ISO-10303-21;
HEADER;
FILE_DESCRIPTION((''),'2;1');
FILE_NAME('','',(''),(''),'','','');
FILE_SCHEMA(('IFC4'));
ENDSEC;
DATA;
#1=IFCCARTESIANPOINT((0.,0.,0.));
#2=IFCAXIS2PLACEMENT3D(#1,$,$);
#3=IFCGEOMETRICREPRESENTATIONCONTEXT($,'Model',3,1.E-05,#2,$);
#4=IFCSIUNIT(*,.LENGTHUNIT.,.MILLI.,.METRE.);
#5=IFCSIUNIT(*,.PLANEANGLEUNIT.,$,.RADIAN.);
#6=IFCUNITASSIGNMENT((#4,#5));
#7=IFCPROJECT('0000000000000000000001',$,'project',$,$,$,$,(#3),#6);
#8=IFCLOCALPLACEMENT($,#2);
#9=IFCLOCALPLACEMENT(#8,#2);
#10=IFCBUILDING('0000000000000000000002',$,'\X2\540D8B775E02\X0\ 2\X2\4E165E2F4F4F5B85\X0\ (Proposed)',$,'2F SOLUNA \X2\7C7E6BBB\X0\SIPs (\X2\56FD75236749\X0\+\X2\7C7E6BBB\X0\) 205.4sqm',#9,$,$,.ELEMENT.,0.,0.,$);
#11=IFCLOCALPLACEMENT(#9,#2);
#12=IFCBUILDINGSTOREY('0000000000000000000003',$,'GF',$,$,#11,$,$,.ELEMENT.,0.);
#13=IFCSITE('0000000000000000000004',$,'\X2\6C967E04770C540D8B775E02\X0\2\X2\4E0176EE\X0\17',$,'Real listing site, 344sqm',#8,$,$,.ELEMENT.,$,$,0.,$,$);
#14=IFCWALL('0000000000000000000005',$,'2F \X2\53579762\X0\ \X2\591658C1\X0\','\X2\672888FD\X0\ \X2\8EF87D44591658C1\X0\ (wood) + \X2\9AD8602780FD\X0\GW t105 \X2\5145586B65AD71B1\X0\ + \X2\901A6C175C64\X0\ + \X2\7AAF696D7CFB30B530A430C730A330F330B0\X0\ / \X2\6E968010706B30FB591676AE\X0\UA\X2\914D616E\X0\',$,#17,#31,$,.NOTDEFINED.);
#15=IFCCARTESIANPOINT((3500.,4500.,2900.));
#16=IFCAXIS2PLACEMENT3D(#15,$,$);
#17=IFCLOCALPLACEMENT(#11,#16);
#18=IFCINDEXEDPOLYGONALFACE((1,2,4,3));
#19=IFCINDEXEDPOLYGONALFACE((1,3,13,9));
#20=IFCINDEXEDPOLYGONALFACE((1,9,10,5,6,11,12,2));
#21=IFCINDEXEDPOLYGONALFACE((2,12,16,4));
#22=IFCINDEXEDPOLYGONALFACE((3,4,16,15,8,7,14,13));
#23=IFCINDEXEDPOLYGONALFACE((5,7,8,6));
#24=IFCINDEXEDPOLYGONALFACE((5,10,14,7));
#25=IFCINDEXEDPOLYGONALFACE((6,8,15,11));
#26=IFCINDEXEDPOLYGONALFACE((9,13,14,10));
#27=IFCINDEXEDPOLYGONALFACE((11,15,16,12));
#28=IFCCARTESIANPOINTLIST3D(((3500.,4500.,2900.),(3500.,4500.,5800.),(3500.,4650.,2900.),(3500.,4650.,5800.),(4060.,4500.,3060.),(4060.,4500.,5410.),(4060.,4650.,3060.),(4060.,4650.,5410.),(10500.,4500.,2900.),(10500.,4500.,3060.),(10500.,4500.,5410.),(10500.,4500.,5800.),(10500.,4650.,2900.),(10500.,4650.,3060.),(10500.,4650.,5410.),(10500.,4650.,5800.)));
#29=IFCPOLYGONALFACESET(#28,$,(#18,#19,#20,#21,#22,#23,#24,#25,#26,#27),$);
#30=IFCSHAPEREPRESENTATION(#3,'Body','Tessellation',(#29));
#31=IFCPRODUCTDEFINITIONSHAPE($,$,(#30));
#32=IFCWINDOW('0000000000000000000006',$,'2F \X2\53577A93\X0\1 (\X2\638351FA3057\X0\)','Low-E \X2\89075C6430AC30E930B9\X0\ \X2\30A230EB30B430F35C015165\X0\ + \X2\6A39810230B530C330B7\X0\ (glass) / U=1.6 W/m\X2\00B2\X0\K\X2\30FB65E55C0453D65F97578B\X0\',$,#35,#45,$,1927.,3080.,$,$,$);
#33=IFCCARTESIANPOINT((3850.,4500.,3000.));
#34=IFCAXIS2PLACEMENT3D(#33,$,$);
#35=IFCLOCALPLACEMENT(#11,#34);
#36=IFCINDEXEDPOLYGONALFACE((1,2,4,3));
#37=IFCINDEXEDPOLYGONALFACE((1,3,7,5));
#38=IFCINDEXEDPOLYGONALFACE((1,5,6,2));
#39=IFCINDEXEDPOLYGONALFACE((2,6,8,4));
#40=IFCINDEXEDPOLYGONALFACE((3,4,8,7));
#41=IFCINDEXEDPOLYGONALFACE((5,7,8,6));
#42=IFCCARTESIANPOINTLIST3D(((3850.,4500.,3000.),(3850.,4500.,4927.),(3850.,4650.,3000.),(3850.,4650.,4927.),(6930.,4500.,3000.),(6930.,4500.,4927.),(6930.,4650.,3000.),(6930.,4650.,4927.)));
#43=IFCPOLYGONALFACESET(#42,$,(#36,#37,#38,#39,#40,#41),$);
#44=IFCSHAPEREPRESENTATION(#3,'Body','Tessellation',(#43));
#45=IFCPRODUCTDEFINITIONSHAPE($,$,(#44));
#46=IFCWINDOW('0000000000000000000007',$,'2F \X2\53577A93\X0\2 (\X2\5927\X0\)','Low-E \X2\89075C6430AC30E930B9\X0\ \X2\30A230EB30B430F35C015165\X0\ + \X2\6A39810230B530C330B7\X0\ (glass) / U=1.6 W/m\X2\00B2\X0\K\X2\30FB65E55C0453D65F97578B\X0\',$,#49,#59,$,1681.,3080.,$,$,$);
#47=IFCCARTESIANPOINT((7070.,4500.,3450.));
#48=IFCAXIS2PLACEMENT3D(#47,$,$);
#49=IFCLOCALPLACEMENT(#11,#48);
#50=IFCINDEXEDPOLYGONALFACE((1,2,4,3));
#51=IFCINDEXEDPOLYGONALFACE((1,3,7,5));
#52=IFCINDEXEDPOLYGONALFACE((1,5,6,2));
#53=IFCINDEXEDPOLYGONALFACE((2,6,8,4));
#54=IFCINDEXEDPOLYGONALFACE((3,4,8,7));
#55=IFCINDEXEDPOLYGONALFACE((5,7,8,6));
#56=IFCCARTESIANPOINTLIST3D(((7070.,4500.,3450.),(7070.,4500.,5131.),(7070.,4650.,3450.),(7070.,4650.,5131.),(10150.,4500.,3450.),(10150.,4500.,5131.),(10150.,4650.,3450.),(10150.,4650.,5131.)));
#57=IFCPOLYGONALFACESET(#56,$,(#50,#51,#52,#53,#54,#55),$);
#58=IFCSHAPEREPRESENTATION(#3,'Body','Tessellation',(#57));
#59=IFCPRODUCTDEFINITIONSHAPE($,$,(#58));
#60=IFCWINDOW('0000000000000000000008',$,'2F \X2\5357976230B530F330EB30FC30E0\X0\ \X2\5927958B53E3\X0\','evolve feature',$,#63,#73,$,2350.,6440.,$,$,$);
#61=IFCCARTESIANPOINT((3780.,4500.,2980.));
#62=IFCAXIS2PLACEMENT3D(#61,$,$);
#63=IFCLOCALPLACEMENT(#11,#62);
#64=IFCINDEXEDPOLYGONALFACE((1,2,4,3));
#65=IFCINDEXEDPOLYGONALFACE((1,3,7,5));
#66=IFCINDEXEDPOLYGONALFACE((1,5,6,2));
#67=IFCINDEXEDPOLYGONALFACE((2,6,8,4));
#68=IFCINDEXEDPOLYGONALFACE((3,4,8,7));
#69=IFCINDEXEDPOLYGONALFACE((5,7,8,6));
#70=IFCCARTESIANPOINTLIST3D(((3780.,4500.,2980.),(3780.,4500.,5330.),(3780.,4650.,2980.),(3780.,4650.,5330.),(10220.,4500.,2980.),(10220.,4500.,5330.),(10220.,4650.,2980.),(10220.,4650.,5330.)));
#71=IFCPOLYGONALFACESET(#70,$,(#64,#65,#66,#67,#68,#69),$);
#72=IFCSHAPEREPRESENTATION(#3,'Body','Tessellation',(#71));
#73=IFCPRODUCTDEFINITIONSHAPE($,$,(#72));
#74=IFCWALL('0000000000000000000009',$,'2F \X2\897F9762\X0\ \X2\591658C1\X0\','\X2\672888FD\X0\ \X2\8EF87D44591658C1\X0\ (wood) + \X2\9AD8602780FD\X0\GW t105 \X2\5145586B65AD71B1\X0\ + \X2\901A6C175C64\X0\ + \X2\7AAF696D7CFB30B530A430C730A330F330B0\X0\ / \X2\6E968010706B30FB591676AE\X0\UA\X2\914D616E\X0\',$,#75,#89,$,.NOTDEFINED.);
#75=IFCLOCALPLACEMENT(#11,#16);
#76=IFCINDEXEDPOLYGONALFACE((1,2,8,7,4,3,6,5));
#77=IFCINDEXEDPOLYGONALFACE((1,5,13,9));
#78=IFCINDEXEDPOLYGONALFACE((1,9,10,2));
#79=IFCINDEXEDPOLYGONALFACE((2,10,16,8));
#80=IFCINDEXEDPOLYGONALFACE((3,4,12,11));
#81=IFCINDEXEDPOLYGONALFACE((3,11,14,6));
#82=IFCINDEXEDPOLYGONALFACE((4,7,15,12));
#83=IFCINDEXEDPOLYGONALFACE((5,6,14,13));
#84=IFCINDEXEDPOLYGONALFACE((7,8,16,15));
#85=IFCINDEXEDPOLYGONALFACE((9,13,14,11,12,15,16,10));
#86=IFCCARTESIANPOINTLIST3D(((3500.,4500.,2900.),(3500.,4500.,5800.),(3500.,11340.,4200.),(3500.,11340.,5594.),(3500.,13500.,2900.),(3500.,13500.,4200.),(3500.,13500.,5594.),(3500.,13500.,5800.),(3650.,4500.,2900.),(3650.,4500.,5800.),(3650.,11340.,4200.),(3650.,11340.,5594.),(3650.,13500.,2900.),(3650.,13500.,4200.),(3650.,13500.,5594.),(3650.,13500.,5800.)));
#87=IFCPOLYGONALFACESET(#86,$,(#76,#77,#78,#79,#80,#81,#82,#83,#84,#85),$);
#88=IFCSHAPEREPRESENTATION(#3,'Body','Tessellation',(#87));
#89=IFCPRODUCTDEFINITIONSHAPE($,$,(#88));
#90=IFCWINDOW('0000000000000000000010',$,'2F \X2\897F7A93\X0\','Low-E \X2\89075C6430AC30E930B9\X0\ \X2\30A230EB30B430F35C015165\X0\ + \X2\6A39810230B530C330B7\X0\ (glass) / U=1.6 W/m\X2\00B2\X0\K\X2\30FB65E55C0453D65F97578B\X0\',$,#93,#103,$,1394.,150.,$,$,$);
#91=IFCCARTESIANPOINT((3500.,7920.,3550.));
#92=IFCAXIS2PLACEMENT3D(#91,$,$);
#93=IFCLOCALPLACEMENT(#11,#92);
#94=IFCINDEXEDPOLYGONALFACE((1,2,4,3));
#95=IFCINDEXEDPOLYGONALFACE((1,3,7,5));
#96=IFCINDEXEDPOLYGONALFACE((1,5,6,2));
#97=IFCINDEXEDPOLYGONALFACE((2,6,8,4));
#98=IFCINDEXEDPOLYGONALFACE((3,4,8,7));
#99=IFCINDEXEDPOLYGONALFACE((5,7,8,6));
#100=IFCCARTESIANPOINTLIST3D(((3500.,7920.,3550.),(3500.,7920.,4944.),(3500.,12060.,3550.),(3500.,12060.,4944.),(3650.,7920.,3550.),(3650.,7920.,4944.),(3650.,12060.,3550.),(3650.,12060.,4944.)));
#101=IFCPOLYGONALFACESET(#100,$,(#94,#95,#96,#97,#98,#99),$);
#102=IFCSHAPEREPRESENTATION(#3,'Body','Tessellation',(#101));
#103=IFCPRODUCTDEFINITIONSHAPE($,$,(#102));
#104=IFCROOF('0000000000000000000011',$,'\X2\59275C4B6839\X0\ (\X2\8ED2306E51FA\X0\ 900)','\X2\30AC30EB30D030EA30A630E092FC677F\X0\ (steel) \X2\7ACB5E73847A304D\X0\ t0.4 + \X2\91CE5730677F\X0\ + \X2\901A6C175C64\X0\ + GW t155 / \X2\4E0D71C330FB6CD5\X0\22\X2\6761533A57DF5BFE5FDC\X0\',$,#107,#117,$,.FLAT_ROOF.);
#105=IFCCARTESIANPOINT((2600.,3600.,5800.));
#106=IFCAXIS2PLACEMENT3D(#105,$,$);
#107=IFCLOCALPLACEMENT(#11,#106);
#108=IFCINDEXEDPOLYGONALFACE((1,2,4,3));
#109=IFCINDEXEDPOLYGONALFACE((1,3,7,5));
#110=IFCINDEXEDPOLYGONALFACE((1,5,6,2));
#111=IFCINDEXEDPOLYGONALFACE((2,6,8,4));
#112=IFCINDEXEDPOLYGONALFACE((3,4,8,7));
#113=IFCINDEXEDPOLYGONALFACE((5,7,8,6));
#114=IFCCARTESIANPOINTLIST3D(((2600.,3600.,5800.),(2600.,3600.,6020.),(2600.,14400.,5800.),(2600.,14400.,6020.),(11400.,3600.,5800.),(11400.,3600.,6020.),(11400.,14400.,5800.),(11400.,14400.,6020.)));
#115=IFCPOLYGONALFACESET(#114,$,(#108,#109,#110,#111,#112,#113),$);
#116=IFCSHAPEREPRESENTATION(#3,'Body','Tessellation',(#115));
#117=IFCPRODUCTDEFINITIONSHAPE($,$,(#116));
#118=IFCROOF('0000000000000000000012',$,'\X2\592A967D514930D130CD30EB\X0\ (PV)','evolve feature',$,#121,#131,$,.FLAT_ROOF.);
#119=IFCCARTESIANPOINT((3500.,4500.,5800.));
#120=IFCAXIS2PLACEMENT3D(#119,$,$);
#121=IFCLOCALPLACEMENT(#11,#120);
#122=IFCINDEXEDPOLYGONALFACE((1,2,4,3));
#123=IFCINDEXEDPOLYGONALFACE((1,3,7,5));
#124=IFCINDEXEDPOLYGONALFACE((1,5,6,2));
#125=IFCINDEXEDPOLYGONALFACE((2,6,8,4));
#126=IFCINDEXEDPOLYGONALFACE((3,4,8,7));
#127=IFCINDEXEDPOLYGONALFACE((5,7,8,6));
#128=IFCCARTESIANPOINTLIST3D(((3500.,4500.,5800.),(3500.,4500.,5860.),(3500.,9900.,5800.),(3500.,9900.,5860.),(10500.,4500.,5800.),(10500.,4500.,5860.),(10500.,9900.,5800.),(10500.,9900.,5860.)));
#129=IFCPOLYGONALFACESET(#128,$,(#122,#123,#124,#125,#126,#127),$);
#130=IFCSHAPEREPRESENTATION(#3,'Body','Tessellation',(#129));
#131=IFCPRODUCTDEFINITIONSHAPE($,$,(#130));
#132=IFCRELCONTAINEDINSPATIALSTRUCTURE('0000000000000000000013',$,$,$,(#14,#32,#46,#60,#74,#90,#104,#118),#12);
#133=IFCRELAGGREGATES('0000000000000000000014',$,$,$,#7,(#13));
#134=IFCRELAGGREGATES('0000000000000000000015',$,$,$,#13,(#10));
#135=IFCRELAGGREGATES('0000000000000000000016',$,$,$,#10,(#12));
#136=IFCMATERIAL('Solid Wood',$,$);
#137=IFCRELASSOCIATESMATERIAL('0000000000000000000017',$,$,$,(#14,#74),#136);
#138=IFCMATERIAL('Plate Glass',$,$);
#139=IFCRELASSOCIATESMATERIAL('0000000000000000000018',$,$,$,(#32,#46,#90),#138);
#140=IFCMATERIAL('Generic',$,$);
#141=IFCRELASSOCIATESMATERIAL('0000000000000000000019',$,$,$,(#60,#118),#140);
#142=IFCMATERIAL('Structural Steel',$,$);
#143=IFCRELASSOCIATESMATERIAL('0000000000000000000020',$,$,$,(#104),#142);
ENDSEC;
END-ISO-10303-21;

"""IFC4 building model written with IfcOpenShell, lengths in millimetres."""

from ifc_helpers import new_model, si_unit, frame, frame_2d, origin, place, context, project, spatial, rectangle, extrude, material, element, fill, save


model = new_model("IFC4")

# Units and contexts
model_context = context("Model", 3, precision=1e-05, world=origin())
ifc_project = project(units=[si_unit("LENGTHUNIT", "METRE", prefix="MILLI"), si_unit("PLANEANGLEUNIT", "RADIAN")], contexts=[model_context])

# Site, building, storey
site_placement = place(None, origin())
site = spatial("IfcSite", under=ifc_project, at=site_placement, Name="沖縄県名護市2丁目17", ObjectType="Real listing site, 344sqm", CompositionType="ELEMENT", RefElevation=0.0)
building_placement = place(site_placement, origin())
building = spatial("IfcBuilding", under=site, at=building_placement, Name="名護市 2世帯住宅 (Proposed)", ObjectType="2F SOLUNA 籾殻SIPs (国産杉+籾殻) 205.4sqm", CompositionType="ELEMENT", ElevationOfRefHeight=0.0, ElevationOfTerrain=0.0)
storey_placement = place(building_placement, origin())
storey = spatial("IfcBuildingStorey", under=building, at=storey_placement, Name="GF", CompositionType="ELEMENT", Elevation=0.0)

# Shared definitions
ifc_material_1 = material(Name="Solid Wood")
ifc_material_2 = material(Name="Generic")

# Shared definitions
ifc_material_3 = material(Name="Plate Glass")

# Wall, openings, windows
wall_1_placement = place(storey_placement, frame((3500.0, 4500.0, 2900.0)))
wall_1 = element("IfcWall", 1, at=wall_1_placement, inside=storey, material=ifc_material_1, Name="2F 南面 外壁", Description="木製 軸組外壁 (wood) + 高性能GW t105 充填断熱 + 通気層 + 窯業系サイディング / 準耐火・外皮UA配慮", PredefinedType="NOTDEFINED", context=model_context, shape_type="SweptSolid", body=[
    extrude(rectangle(XDim=7000.0, YDim=150.0, at=frame_2d((3500.0, 75.0))), frame((3500.0, 4500.0, 2900.0)), (0.0, 0.0, 1.0), 2900.0),
])
opening_1_placement = place(storey_placement, frame((3850.0, 4500.0, 3000.0)))
opening_1 = element("IfcOpeningElement", 2, at=opening_1_placement, cuts=wall_1, PredefinedType="NOTDEFINED", context=model_context, shape_type="SweptSolid", body=[
    extrude(rectangle(XDim=3080.0, YDim=150.0, at=frame_2d((1540.0, 75.0))), frame((3850.0, 4500.0, 3000.0)), (0.0, 0.0, 1.0), 1927.0),
])
opening_2_placement = place(storey_placement, frame((7070.0, 4500.0, 3450.0)))
opening_2 = element("IfcOpeningElement", 3, at=opening_2_placement, cuts=wall_1, PredefinedType="NOTDEFINED", context=model_context, shape_type="SweptSolid", body=[
    extrude(rectangle(XDim=3080.0, YDim=150.0, at=frame_2d((1540.0, 75.0))), frame((7070.0, 4500.0, 3450.0)), (0.0, 0.0, 1.0), 1681.0),
])
opening_3_placement = place(storey_placement, frame((3780.0, 4500.0, 2980.0)))
opening_3 = element("IfcOpeningElement", 4, at=opening_3_placement, cuts=wall_1, PredefinedType="NOTDEFINED", context=model_context, shape_type="SweptSolid", body=[
    extrude(rectangle(XDim=6440.0, YDim=150.0, at=frame_2d((3220.0, 75.0))), frame((3780.0, 4500.0, 2980.0)), (0.0, 0.0, 1.0), 2350.0),
])
window_1_placement = place(storey_placement, frame((3850.0, 4500.0, 3000.0)))
window_1 = element("IfcWindow", 5, at=window_1_placement, inside=storey, material=ifc_material_3, Name="2F 南窓1 (掃出し)", Description="Low-E 複層ガラス アルゴン封入 + 樹脂サッシ (glass) / U=1.6 W/m²K・日射取得型", OverallHeight=1927.0, OverallWidth=3080.0, context=model_context, shape_type="SweptSolid", body=[
    extrude(rectangle(XDim=3080.0, YDim=150.0, at=frame_2d((1540.0, 75.0))), frame((3850.0, 4500.0, 3000.0)), (0.0, 0.0, 1.0), 1927.0),
])
fill(opening_1, window_1)
window_2_placement = place(storey_placement, frame((7070.0, 4500.0, 3450.0)))
window_2 = element("IfcWindow", 6, at=window_2_placement, inside=storey, material=ifc_material_3, Name="2F 南窓2 (大)", Description="Low-E 複層ガラス アルゴン封入 + 樹脂サッシ (glass) / U=1.6 W/m²K・日射取得型", OverallHeight=1681.0, OverallWidth=3080.0, context=model_context, shape_type="SweptSolid", body=[
    extrude(rectangle(XDim=3080.0, YDim=150.0, at=frame_2d((1540.0, 75.0))), frame((7070.0, 4500.0, 3450.0)), (0.0, 0.0, 1.0), 1681.0),
])
fill(opening_2, window_2)
window_3_placement = place(storey_placement, frame((3780.0, 4500.0, 2980.0)))
window_3 = element("IfcWindow", 7, at=window_3_placement, inside=storey, material=ifc_material_2, Name="2F 南面サンルーム 大開口", Description="evolve feature", OverallHeight=2350.0, OverallWidth=6440.0, context=model_context, shape_type="SweptSolid", body=[
    extrude(rectangle(XDim=6440.0, YDim=150.0, at=frame_2d((3220.0, 75.0))), frame((3780.0, 4500.0, 2980.0)), (0.0, 0.0, 1.0), 2350.0),
])
fill(opening_3, window_3)

# Wall, opening, window
wall_2_placement = place(storey_placement, frame((3500.0, 4500.0, 2900.0)))
wall_2 = element("IfcWall", 8, at=wall_2_placement, inside=storey, material=ifc_material_1, Name="2F 西面 外壁", Description="木製 軸組外壁 (wood) + 高性能GW t105 充填断熱 + 通気層 + 窯業系サイディング / 準耐火・外皮UA配慮", PredefinedType="NOTDEFINED", context=model_context, shape_type="SweptSolid", body=[
    extrude(rectangle(XDim=150.0, YDim=9000.0, at=frame_2d((75.0, 4500.0))), frame((3500.0, 4500.0, 2900.0)), (0.0, 0.0, 1.0), 2900.0),
])
opening_4_placement = place(storey_placement, frame((3500.0, 7920.0, 3550.0)))
opening_4 = element("IfcOpeningElement", 9, at=opening_4_placement, cuts=wall_2, PredefinedType="NOTDEFINED", context=model_context, shape_type="SweptSolid", body=[
    extrude(rectangle(XDim=150.0, YDim=4140.0, at=frame_2d((75.0, 2070.0))), frame((3500.0, 7920.0, 3550.0)), (0.0, 0.0, 1.0), 1394.0),
])
window_4_placement = place(storey_placement, frame((3500.0, 7920.0, 3550.0)))
window_4 = element("IfcWindow", 10, at=window_4_placement, inside=storey, material=ifc_material_3, Name="2F 西窓", Description="Low-E 複層ガラス アルゴン封入 + 樹脂サッシ (glass) / U=1.6 W/m²K・日射取得型", OverallHeight=1394.0, OverallWidth=150.0, context=model_context, shape_type="SweptSolid", body=[
    extrude(rectangle(XDim=150.0, YDim=4140.0, at=frame_2d((75.0, 2070.0))), frame((3500.0, 7920.0, 3550.0)), (0.0, 0.0, 1.0), 1394.0),
])
fill(opening_4, window_4)

# Roofs
ifc_material_4 = material(Name="Structural Steel")
roof_1_placement = place(storey_placement, frame((2600.0, 3600.0, 5800.0)))
element("IfcRoof", 11, at=roof_1_placement, inside=storey, material=ifc_material_4, Name="大屋根 (軒の出 900)", Description="ガルバリウム鋼板 (steel) 立平葺き t0.4 + 野地板 + 通気層 + GW t155 / 不燃・法22条区域対応", PredefinedType="FLAT_ROOF", context=model_context, shape_type="SweptSolid", body=[
    extrude(rectangle(XDim=8800.0, YDim=10800.0, at=frame_2d((4400.0, 5400.0))), frame((2600.0, 3600.0, 5800.0)), (0.0, 0.0, 1.0), 220.0),
])
roof_2_placement = place(storey_placement, frame((3500.0, 4500.0, 5800.0)))
element("IfcRoof", 12, at=roof_2_placement, inside=storey, material=ifc_material_2, Name="太陽光パネル (PV)", Description="evolve feature", PredefinedType="FLAT_ROOF", context=model_context, shape_type="SweptSolid", body=[
    extrude(rectangle(XDim=7000.0, YDim=5400.0, at=frame_2d((3500.0, 2700.0))), frame((3500.0, 4500.0, 5800.0)), (0.0, 0.0, 1.0), 60.0),
])

save(model, "model.ifc")
